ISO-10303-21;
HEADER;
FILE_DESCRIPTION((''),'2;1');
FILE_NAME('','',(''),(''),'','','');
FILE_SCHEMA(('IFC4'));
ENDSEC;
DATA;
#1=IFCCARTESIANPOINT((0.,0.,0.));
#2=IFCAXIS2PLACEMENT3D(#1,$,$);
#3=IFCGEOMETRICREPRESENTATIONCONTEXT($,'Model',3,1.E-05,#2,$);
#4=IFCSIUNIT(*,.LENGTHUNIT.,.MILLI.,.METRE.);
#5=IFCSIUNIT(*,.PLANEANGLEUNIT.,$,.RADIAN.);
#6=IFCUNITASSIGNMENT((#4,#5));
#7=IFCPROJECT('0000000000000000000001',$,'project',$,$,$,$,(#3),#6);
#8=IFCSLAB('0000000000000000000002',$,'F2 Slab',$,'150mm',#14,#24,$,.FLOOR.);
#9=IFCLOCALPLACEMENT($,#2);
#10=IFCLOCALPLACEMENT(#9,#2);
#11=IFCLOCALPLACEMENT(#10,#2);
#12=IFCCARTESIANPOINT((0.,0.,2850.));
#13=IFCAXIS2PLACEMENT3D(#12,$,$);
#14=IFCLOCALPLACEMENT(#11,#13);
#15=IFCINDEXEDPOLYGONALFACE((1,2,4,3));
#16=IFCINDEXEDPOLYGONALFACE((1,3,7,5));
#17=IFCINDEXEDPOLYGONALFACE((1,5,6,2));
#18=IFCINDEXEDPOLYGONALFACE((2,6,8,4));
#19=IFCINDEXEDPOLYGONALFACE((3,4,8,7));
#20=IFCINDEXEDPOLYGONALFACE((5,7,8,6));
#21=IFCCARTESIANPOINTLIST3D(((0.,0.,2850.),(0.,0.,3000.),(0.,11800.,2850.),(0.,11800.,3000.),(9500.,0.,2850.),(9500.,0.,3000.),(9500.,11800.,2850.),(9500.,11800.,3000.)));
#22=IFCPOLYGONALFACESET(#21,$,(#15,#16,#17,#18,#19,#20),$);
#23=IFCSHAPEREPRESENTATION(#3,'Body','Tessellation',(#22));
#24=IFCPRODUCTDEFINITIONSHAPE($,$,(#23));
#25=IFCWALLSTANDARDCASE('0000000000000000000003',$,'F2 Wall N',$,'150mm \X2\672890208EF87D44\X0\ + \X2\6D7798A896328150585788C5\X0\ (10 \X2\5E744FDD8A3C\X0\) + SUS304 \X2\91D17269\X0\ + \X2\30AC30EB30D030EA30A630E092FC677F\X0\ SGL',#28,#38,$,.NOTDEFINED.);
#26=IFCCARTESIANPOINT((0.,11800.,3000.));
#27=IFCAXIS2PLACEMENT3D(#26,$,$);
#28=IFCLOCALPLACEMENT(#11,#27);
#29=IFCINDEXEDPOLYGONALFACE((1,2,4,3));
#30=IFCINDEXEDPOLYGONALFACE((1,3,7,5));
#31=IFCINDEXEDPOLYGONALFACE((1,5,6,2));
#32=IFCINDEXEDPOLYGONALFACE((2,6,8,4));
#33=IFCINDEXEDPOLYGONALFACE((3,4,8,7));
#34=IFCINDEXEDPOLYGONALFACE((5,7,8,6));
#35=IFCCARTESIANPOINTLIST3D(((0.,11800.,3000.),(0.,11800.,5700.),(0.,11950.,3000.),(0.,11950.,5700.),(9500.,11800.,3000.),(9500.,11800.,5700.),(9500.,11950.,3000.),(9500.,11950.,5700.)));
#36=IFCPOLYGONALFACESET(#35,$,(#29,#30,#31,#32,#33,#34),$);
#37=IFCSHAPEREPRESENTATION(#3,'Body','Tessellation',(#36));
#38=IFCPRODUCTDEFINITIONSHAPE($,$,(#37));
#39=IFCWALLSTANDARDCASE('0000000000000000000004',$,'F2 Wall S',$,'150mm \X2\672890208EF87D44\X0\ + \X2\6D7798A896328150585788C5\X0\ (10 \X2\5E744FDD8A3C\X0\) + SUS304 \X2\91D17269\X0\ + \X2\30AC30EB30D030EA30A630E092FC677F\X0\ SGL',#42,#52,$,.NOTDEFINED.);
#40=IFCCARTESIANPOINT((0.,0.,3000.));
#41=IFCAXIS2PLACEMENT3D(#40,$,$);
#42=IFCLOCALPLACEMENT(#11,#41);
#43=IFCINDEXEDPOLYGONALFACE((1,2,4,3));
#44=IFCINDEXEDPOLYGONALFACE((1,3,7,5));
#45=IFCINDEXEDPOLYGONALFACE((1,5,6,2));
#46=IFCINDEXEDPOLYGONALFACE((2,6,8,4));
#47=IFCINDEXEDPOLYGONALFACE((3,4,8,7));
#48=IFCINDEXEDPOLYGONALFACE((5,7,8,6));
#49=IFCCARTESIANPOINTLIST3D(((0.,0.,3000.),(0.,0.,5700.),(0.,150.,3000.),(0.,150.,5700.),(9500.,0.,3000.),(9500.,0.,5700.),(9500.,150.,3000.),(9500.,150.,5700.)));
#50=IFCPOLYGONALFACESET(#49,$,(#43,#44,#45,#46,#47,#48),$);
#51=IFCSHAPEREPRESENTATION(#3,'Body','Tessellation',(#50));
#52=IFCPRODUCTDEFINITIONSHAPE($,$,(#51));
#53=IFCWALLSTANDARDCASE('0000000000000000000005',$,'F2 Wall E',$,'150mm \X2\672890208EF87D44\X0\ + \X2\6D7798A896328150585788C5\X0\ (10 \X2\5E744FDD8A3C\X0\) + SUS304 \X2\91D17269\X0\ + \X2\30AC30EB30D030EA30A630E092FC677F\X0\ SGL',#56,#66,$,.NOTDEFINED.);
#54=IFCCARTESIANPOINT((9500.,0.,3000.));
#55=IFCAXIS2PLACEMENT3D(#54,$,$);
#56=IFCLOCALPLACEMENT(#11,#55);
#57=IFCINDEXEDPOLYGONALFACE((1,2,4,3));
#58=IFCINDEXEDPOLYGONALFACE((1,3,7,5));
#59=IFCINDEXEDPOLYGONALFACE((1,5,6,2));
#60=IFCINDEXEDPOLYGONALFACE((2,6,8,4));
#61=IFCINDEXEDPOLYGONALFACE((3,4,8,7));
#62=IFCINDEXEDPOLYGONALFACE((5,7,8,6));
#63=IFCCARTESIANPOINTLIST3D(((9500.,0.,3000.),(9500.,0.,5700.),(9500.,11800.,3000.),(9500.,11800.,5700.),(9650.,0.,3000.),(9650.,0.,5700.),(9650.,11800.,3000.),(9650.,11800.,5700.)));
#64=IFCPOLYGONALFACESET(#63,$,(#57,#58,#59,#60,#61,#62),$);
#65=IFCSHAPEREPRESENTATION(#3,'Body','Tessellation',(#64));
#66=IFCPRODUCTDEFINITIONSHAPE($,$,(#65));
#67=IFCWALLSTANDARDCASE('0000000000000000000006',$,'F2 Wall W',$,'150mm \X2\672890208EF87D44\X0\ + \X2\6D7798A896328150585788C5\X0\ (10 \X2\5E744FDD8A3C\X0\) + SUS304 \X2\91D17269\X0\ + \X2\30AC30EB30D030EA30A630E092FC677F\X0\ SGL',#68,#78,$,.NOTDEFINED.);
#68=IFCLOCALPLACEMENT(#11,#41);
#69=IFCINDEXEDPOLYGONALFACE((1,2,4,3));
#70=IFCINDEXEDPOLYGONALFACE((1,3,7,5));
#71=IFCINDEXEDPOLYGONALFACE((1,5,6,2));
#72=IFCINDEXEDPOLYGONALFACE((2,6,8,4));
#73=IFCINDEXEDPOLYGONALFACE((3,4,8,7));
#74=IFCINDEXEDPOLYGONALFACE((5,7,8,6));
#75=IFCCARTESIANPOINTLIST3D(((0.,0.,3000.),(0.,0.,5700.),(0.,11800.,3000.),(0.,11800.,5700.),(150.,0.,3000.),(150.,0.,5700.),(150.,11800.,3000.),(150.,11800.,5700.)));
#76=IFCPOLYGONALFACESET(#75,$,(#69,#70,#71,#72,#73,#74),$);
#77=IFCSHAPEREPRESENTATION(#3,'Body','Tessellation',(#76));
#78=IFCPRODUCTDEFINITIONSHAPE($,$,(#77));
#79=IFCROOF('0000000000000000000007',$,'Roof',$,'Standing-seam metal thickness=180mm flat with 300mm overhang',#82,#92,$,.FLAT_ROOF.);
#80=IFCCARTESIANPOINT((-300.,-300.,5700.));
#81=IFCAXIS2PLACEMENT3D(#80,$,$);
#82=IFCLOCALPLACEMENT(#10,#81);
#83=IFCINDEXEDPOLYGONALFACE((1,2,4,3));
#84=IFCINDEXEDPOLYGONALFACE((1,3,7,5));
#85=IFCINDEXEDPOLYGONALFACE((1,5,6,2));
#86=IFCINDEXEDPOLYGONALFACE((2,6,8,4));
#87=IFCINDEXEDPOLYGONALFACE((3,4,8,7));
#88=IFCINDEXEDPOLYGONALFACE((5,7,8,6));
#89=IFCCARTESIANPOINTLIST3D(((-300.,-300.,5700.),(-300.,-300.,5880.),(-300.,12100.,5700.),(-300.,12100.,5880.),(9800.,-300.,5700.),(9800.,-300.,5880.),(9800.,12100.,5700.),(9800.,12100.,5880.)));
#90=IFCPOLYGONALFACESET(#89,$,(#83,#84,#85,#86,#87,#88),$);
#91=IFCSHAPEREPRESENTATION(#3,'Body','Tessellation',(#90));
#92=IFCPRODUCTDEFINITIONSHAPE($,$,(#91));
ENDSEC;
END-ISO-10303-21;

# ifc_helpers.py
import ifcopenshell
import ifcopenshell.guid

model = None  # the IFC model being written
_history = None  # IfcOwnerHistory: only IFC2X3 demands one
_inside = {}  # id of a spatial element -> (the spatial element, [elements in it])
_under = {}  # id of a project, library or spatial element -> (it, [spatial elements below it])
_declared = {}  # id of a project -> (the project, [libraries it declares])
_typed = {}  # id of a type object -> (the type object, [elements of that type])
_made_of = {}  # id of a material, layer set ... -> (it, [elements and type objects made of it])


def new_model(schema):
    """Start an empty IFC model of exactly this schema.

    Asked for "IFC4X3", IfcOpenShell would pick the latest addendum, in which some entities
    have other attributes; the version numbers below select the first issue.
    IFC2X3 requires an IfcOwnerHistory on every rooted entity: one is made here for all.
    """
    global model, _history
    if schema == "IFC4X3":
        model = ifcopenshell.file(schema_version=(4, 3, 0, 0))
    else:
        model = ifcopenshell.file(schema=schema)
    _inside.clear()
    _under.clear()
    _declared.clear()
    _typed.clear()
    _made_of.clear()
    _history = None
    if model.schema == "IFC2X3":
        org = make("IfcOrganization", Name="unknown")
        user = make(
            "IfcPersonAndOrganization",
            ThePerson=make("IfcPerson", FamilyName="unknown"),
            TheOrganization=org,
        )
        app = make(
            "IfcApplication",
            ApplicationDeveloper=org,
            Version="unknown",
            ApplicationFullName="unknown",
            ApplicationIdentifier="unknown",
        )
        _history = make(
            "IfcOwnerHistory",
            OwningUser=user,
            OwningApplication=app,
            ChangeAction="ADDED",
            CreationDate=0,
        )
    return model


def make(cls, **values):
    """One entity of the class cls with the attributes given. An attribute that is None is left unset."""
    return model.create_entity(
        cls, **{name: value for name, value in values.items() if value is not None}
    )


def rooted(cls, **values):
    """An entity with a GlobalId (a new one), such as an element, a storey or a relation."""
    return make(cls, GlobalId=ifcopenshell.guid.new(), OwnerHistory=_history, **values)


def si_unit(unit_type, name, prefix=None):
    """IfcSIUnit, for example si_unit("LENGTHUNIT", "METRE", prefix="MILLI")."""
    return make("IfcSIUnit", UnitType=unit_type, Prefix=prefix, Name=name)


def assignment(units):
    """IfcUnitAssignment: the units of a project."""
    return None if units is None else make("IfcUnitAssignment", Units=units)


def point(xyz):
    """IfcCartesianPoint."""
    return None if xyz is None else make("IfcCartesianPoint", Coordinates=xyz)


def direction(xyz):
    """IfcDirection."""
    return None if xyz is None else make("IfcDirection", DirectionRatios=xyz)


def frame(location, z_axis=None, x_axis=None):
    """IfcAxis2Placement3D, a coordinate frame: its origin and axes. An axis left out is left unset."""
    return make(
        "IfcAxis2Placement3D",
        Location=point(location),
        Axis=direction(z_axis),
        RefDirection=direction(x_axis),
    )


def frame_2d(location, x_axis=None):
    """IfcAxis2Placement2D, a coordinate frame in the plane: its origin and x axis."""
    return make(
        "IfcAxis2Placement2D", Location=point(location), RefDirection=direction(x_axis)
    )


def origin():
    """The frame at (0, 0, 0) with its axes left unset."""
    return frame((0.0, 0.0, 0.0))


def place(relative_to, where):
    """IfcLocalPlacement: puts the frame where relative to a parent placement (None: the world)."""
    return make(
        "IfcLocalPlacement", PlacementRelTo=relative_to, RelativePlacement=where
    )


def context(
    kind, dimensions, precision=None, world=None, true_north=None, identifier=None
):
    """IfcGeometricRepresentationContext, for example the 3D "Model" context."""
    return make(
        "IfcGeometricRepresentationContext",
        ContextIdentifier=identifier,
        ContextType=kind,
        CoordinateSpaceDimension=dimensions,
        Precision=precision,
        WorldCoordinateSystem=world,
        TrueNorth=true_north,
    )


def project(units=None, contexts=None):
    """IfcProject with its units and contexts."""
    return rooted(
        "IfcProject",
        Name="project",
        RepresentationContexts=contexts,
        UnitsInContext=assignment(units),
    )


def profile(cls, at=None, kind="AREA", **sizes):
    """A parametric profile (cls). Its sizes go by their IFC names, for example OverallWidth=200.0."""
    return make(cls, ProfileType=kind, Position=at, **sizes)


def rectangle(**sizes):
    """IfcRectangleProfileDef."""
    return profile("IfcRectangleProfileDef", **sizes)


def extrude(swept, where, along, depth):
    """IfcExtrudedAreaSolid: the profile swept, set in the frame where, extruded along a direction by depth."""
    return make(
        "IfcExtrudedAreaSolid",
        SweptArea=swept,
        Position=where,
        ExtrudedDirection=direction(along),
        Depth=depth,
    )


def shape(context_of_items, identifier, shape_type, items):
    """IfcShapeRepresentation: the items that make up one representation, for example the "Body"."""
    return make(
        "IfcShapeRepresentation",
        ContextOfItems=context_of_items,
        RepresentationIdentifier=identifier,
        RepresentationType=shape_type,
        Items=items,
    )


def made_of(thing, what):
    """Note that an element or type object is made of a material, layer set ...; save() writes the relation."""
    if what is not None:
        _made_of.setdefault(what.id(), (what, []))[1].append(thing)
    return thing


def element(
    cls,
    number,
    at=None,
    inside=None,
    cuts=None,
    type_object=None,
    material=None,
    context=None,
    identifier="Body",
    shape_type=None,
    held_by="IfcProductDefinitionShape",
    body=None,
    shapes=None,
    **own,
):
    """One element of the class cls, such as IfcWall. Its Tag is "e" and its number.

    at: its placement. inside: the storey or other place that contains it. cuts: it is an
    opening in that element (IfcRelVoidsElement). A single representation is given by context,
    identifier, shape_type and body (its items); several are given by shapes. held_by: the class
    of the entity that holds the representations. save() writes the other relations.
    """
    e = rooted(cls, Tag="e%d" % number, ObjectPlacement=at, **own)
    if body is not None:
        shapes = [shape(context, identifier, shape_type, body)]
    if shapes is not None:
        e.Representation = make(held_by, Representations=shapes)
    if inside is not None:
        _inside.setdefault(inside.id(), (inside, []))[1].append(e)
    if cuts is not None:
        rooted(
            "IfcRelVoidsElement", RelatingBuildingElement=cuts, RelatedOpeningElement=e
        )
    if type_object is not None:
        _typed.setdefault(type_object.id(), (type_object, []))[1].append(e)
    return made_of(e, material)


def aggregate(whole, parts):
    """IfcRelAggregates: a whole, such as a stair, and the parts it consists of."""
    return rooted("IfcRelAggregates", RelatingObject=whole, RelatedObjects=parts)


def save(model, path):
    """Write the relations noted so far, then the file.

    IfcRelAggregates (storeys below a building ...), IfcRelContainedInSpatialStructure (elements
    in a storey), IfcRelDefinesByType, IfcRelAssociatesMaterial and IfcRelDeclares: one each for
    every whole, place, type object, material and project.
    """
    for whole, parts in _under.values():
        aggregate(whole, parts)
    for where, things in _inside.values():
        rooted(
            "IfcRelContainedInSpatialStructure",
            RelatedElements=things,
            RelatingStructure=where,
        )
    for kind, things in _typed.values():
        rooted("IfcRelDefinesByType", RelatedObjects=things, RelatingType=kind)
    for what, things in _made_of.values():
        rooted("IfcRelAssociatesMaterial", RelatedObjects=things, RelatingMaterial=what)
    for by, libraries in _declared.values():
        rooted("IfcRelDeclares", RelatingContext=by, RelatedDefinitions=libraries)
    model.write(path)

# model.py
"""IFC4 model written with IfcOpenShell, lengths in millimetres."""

from ifc_helpers import new_model, si_unit, frame, frame_2d, origin, place, context, project, rectangle, extrude, element, save


model = new_model("IFC4")

# Units and contexts
model_context = context("Model", 3, precision=1e-05, world=origin())
ifc_project = project(units=[si_unit("LENGTHUNIT", "METRE", prefix="MILLI"), si_unit("PLANEANGLEUNIT", "RADIAN")], contexts=[model_context])

# Slab
placement_1 = place(None, origin())
placement_2 = place(placement_1, origin())
placement_3 = place(placement_2, origin())
slab_placement = place(placement_3, frame((0.0, 0.0, 2850.0)))
element("IfcSlab", 1, at=slab_placement, Name="F2 Slab", ObjectType="150mm", PredefinedType="FLOOR", context=model_context, shape_type="SweptSolid", body=[
    extrude(rectangle(XDim=9500.0, YDim=11800.0, at=frame_2d((4750.0, 5900.0))), frame((0.0, 0.0, 2850.0)), (0.0, 0.0, 1.0), 150.0),
])

# Walls
wall_1_placement = place(placement_3, frame((0.0, 11800.0, 3000.0)))
element("IfcWallStandardCase", 2, at=wall_1_placement, Name="F2 Wall N", ObjectType="150mm 木造軸組 + 海風防腐塗装 (10 年保証) + SUS304 金物 + ガルバリウム鋼板 SGL", PredefinedType="NOTDEFINED", context=model_context, shape_type="SweptSolid", body=[
    extrude(rectangle(XDim=9500.0, YDim=150.0, at=frame_2d((4750.0, 75.0))), frame((0.0, 11800.0, 3000.0)), (0.0, 0.0, 1.0), 2700.0),
])
wall_2_placement = place(placement_3, frame((0.0, 0.0, 3000.0)))
element("IfcWallStandardCase", 3, at=wall_2_placement, Name="F2 Wall S", ObjectType="150mm 木造軸組 + 海風防腐塗装 (10 年保証) + SUS304 金物 + ガルバリウム鋼板 SGL", PredefinedType="NOTDEFINED", context=model_context, shape_type="SweptSolid", body=[
    extrude(rectangle(XDim=9500.0, YDim=150.0, at=frame_2d((4750.0, 75.0))), frame((0.0, 0.0, 3000.0)), (0.0, 0.0, 1.0), 2700.0),
])
wall_3_placement = place(placement_3, frame((9500.0, 0.0, 3000.0)))
element("IfcWallStandardCase", 4, at=wall_3_placement, Name="F2 Wall E", ObjectType="150mm 木造軸組 + 海風防腐塗装 (10 年保証) + SUS304 金物 + ガルバリウム鋼板 SGL", PredefinedType="NOTDEFINED", context=model_context, shape_type="SweptSolid", body=[
    extrude(rectangle(XDim=150.0, YDim=11800.0, at=frame_2d((75.0, 5900.0))), frame((9500.0, 0.0, 3000.0)), (0.0, 0.0, 1.0), 2700.0),
])
wall_4_placement = place(placement_3, frame((0.0, 0.0, 3000.0)))
element("IfcWallStandardCase", 5, at=wall_4_placement, Name="F2 Wall W", ObjectType="150mm 木造軸組 + 海風防腐塗装 (10 年保証) + SUS304 金物 + ガルバリウム鋼板 SGL", PredefinedType="NOTDEFINED", context=model_context, shape_type="SweptSolid", body=[
    extrude(rectangle(XDim=150.0, YDim=11800.0, at=frame_2d((75.0, 5900.0))), frame((0.0, 0.0, 3000.0)), (0.0, 0.0, 1.0), 2700.0),
])

# Roof
roof_placement = place(placement_2, frame((-300.0, -300.0, 5700.0)))
element("IfcRoof", 6, at=roof_placement, Name="Roof", ObjectType="Standing-seam metal thickness=180mm flat with 300mm overhang", PredefinedType="FLAT_ROOF", context=model_context, shape_type="SweptSolid", body=[
    extrude(rectangle(XDim=10100.0, YDim=12400.0, at=frame_2d((5050.0, 6200.0))), frame((-300.0, -300.0, 5700.0)), (0.0, 0.0, 1.0), 180.0),
])

save(model, "model.ifc")
